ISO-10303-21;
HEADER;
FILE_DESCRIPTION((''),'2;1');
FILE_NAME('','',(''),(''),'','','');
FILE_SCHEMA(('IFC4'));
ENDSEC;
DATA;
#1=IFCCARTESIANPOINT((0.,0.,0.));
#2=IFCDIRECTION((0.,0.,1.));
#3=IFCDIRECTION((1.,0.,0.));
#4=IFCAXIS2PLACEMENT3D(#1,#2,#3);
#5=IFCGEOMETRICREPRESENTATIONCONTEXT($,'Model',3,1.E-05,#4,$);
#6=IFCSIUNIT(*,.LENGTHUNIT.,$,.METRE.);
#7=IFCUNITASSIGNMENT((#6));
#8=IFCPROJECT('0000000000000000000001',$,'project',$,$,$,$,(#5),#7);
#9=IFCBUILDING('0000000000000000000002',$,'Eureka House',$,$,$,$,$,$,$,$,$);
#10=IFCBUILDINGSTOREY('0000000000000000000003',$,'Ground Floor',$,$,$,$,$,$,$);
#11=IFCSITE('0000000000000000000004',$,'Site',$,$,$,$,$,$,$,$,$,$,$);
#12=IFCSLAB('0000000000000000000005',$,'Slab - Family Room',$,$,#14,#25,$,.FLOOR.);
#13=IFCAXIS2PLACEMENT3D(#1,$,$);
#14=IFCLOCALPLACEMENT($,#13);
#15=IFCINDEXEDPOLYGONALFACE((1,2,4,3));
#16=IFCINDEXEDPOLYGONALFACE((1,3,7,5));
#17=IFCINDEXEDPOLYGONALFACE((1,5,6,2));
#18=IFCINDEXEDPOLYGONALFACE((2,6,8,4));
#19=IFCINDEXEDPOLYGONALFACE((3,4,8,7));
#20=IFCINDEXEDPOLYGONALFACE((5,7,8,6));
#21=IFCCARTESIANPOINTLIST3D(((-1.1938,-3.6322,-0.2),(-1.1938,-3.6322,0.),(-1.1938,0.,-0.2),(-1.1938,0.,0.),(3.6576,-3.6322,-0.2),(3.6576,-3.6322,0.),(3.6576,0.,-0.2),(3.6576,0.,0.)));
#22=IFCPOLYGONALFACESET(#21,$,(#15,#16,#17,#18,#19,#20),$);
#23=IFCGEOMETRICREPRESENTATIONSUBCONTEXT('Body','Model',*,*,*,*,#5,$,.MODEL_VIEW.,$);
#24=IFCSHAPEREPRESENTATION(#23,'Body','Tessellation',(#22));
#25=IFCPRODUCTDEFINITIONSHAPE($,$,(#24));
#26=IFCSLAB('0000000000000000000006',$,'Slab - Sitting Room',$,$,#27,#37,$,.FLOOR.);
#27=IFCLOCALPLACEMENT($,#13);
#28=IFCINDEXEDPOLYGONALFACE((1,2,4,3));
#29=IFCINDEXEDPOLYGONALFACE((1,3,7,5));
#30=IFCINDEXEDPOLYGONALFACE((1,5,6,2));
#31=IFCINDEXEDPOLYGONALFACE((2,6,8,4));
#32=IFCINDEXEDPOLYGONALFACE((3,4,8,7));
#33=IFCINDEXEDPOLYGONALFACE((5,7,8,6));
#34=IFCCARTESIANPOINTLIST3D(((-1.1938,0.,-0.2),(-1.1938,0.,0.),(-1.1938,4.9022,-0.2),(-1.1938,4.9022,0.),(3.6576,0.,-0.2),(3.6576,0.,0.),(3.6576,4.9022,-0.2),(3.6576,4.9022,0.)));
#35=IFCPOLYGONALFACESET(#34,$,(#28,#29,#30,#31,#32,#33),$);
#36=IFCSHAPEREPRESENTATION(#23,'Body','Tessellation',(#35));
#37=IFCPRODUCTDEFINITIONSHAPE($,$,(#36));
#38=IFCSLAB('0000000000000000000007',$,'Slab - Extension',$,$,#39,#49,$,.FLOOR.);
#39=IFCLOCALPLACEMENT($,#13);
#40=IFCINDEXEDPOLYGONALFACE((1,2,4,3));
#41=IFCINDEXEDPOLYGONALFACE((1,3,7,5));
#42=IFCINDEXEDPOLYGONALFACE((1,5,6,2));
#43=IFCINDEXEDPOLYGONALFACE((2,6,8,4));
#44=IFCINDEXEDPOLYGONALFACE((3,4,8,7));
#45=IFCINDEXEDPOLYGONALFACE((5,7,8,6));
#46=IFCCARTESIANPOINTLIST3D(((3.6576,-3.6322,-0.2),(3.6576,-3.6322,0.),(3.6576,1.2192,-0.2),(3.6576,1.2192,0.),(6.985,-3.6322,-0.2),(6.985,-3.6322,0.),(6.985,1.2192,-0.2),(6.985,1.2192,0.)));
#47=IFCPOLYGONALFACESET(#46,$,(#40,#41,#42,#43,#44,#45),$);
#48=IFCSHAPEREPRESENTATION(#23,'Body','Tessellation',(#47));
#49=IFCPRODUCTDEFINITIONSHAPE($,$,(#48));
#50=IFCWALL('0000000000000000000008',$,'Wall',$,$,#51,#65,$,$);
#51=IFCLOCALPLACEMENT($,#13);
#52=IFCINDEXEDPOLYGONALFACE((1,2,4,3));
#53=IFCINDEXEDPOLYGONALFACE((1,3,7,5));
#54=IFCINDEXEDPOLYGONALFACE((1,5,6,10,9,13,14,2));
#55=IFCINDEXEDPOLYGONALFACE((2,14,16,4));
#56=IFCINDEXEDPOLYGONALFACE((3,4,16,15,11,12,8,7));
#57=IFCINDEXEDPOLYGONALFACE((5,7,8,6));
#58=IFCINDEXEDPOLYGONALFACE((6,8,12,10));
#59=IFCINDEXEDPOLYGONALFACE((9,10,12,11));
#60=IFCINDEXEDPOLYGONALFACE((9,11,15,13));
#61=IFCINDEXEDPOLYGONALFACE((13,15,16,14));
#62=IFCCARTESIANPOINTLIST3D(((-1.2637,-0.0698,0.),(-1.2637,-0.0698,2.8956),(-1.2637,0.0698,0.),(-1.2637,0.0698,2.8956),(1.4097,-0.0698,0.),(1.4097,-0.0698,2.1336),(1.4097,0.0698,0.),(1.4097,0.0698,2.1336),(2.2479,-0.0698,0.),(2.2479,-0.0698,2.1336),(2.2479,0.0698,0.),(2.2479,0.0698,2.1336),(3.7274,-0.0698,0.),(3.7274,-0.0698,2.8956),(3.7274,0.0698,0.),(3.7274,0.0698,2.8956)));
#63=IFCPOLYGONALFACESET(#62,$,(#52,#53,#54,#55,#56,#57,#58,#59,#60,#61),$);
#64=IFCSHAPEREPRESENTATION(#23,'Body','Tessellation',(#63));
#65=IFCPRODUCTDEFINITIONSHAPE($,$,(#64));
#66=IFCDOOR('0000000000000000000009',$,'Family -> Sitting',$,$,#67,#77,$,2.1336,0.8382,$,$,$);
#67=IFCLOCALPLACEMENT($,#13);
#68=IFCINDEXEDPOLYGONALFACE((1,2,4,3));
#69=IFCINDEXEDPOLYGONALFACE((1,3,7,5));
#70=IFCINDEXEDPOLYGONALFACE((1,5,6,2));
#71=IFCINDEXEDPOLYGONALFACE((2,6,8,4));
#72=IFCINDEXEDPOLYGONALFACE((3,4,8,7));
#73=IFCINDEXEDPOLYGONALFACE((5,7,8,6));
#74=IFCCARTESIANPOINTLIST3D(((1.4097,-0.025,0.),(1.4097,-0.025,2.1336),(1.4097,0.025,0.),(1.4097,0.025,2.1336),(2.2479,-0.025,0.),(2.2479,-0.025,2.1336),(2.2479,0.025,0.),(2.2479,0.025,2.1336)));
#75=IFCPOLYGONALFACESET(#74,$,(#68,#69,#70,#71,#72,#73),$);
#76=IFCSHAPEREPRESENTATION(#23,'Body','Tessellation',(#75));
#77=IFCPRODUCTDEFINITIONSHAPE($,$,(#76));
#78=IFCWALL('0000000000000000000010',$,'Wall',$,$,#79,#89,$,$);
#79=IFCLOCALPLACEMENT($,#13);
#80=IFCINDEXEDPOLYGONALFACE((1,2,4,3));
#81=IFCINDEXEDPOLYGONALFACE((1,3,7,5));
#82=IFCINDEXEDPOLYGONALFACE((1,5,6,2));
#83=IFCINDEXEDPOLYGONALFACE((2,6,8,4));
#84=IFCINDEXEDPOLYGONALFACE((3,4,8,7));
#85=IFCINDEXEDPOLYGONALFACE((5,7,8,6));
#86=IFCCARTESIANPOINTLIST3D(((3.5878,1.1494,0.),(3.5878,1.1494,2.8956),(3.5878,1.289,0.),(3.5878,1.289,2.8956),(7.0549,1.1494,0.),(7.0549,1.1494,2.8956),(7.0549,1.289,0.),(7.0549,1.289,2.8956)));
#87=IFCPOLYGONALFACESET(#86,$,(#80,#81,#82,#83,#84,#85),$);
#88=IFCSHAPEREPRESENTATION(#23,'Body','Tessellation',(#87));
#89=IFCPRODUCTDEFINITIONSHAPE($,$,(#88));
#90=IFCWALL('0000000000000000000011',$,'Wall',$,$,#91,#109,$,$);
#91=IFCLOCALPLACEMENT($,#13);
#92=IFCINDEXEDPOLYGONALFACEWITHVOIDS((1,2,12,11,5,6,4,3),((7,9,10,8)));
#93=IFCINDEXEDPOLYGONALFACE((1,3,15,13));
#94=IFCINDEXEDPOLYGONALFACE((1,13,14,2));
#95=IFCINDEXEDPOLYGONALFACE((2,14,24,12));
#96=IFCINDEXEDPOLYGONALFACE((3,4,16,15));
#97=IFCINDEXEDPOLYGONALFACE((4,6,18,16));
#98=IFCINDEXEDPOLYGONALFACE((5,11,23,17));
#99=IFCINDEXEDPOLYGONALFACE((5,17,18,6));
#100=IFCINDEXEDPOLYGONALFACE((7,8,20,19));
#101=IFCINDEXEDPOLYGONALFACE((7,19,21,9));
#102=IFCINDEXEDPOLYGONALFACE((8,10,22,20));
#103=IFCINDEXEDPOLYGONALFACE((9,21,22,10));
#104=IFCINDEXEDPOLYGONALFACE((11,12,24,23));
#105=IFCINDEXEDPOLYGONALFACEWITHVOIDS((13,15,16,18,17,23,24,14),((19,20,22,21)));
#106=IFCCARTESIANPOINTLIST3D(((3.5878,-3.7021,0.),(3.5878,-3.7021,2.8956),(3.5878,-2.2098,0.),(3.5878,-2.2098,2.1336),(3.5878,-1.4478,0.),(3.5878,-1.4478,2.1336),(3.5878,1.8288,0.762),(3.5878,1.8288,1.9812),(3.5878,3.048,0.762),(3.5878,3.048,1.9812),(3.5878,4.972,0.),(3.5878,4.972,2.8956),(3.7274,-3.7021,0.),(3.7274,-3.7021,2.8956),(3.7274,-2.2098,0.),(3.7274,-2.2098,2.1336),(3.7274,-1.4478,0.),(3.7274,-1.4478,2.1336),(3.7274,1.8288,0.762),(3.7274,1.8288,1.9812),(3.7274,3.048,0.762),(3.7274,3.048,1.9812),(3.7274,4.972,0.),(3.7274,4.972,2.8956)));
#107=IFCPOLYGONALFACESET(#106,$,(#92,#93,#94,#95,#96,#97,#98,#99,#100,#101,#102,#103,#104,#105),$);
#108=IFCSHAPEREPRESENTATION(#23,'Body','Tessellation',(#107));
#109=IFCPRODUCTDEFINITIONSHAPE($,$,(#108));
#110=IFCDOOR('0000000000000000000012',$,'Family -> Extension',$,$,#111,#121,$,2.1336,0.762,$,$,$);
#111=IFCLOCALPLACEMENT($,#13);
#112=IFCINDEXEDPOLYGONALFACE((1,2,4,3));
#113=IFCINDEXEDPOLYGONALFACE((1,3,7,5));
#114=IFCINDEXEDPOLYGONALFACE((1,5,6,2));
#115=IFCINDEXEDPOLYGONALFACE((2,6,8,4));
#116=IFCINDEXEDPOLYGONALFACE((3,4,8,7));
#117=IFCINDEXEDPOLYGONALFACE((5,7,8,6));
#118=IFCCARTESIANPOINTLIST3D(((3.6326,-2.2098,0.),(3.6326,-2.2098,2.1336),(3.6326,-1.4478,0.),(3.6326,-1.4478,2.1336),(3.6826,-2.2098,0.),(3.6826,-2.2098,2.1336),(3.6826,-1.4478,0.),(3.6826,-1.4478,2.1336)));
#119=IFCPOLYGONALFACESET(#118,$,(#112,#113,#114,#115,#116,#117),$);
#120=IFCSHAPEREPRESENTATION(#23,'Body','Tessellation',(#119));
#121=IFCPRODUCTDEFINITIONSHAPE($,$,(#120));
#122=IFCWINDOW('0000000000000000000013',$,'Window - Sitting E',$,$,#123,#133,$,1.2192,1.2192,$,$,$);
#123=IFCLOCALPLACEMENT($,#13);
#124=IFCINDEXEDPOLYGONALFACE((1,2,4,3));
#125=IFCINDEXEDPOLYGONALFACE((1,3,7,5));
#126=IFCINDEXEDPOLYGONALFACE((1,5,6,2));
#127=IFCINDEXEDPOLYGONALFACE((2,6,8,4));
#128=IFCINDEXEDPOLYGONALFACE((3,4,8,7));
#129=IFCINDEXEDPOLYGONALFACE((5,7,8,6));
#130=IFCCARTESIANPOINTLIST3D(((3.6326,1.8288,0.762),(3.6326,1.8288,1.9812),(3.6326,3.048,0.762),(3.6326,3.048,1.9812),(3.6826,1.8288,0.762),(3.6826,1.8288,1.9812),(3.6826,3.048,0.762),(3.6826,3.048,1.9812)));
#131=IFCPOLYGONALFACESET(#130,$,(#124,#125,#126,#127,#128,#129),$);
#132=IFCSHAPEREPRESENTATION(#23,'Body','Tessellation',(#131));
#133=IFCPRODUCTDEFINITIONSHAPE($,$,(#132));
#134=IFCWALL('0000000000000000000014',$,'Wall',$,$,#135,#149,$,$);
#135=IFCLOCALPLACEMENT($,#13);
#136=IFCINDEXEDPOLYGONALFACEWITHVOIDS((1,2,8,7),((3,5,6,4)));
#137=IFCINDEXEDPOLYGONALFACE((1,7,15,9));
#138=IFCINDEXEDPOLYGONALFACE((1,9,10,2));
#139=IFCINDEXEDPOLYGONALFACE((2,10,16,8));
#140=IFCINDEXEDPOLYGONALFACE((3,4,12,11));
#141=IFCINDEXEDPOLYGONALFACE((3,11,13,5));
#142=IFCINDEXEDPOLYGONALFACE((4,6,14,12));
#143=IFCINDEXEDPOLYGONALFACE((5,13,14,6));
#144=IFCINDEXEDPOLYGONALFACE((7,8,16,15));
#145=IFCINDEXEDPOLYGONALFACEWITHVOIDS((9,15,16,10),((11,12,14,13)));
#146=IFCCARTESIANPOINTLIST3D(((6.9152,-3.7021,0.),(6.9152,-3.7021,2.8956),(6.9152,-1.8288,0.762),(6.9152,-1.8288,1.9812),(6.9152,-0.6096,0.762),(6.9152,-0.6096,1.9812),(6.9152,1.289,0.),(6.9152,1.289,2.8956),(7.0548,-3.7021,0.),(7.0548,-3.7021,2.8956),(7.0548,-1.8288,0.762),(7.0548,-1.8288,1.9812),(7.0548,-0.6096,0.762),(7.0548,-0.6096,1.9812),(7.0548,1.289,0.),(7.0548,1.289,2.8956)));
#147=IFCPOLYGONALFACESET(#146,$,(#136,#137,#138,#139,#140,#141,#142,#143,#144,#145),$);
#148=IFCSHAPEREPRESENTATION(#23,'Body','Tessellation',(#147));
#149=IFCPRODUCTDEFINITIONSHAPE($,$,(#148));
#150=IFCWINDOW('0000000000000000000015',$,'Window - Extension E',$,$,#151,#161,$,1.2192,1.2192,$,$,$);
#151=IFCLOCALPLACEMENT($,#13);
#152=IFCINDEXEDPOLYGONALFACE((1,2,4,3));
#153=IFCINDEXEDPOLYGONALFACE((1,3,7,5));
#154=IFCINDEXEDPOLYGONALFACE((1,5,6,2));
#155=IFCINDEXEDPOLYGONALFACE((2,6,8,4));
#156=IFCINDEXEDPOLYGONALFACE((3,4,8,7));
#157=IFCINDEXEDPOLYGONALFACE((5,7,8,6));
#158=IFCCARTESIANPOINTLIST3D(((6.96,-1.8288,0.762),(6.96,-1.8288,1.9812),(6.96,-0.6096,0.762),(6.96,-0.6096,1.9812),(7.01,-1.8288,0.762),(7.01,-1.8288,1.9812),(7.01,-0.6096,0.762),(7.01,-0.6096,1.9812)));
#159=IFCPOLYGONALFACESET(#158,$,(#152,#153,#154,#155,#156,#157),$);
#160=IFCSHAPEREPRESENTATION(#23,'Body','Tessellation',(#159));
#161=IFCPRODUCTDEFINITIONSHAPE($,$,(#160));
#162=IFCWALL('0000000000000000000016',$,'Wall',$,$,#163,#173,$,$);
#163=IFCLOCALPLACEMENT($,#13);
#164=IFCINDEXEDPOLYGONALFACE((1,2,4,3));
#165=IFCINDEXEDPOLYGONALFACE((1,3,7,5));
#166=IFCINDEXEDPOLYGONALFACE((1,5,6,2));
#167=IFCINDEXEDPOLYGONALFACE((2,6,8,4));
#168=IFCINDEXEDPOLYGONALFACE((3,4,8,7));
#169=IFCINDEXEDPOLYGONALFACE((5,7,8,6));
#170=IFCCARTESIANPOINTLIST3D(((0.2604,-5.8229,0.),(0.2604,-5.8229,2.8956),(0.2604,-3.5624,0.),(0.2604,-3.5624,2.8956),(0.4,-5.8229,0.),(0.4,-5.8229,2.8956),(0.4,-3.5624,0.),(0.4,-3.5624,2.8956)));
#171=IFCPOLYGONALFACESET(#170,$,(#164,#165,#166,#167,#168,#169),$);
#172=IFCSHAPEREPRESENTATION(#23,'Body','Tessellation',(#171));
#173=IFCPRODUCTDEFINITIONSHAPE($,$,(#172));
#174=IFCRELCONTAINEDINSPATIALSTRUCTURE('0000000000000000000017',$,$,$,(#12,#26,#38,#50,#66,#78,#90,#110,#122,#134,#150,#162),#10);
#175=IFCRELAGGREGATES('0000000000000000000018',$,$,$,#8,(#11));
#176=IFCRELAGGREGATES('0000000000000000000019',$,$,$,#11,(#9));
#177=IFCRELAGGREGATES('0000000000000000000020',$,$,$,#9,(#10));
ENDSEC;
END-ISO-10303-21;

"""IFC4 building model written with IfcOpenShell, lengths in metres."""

from ifc_helpers import new_model, si_unit, frame, origin, origin_with_axes, origin_2d, place, context, subcontext, project, spatial, rectangle, extrude, element, fill, save


model = new_model("IFC4")

# Units and contexts
model_context = context("Model", 3, precision=1e-05, world=origin_with_axes())
body_context = subcontext(model_context, "Body", "Model", "MODEL_VIEW")
ifc_project = project(units=[si_unit("LENGTHUNIT", "METRE")], contexts=[model_context])

# Site, building, storey
site = spatial("IfcSite", under=ifc_project, Name="Site")
building = spatial("IfcBuilding", under=site, Name="Eureka House")
storey = spatial("IfcBuildingStorey", under=building, Name="Ground Floor")

# Slabs
slab_1_placement = place(None, frame((1.2319, -1.8161, -0.2), z_axis=(0.0, 0.0, 1.0), x_axis=(1.0, 0.0, 0.0)))
element("IfcSlab", 1, at=slab_1_placement, inside=storey, Name="Slab - Family Room", PredefinedType="FLOOR", context=body_context, shape_type="SweptSolid", body=[
    extrude(rectangle(XDim=4.8514, YDim=3.6322, at=origin_2d()), origin(), (0.0, 0.0, 1.0), 0.2),
])
slab_2_placement = place(None, frame((1.2319, 2.4511, -0.2), z_axis=(0.0, 0.0, 1.0), x_axis=(1.0, 0.0, 0.0)))
element("IfcSlab", 2, at=slab_2_placement, inside=storey, Name="Slab - Sitting Room", PredefinedType="FLOOR", context=body_context, shape_type="SweptSolid", body=[
    extrude(rectangle(XDim=4.8514, YDim=4.9022, at=origin_2d()), origin(), (0.0, 0.0, 1.0), 0.2),
])
slab_3_placement = place(None, frame((5.3213, -1.2065, -0.2), z_axis=(0.0, 0.0, 1.0), x_axis=(1.0, 0.0, 0.0)))
element("IfcSlab", 3, at=slab_3_placement, inside=storey, Name="Slab - Extension", PredefinedType="FLOOR", context=body_context, shape_type="SweptSolid", body=[
    extrude(rectangle(XDim=3.3274, YDim=4.8514, at=origin_2d()), origin(), (0.0, 0.0, 1.0), 0.2),
])

# Wall, opening, door
wall_1_placement = place(None, frame((1.2319, 0.0, 0.0), z_axis=(0.0, 0.0, 1.0), x_axis=(1.0, 0.0, 0.0)))
wall_1 = element("IfcWall", 4, at=wall_1_placement, inside=storey, Name="Wall", context=body_context, shape_type="SweptSolid", body=[
    extrude(rectangle(XDim=4.9911, YDim=0.1397, at=origin_2d()), origin(), (0.0, 0.0, 1.0), 2.8956),
])
opening_1_placement = place(wall_1_placement, frame((0.5969, 0.0, 0.0), z_axis=(0.0, 0.0, 1.0), x_axis=(1.0, 0.0, 0.0)))
opening_1 = element("IfcOpeningElement", 5, at=opening_1_placement, cuts=wall_1, context=body_context, shape_type="SweptSolid", body=[
    extrude(rectangle(XDim=0.8382, YDim=0.2397, at=origin_2d()), origin(), (0.0, 0.0, 1.0), 2.1336),
])
door_1_placement = place(opening_1_placement, origin_with_axes())
door_1 = element("IfcDoor", 6, at=door_1_placement, inside=storey, Name="Family -> Sitting", OverallHeight=2.1336, OverallWidth=0.8382, context=body_context, shape_type="SweptSolid", body=[
    extrude(rectangle(XDim=0.8382, YDim=0.05, at=origin_2d()), origin(), (0.0, 0.0, 1.0), 2.1336),
])
fill(opening_1, door_1)

# Wall
wall_2_placement = place(None, frame((5.3213, 1.2192, 0.0), z_axis=(0.0, 0.0, 1.0), x_axis=(1.0, 0.0, 0.0)))
element("IfcWall", 7, at=wall_2_placement, inside=storey, Name="Wall", context=body_context, shape_type="SweptSolid", body=[
    extrude(rectangle(XDim=3.4671, YDim=0.1397, at=origin_2d()), origin(), (0.0, 0.0, 1.0), 2.8956),
])

# Wall, openings, door, window
wall_3_placement = place(None, frame((3.6576, 0.635, 0.0), z_axis=(0.0, 0.0, 1.0), x_axis=(1.0, 0.0, 0.0)))
wall_3 = element("IfcWall", 8, at=wall_3_placement, inside=storey, Name="Wall", context=body_context, shape_type="SweptSolid", body=[
    extrude(rectangle(XDim=0.1397, YDim=8.6741, at=origin_2d()), origin(), (0.0, 0.0, 1.0), 2.8956),
])
opening_2_placement = place(wall_3_placement, frame((0.0, -2.4638, 0.0), z_axis=(0.0, 0.0, 1.0), x_axis=(1.0, 0.0, 0.0)))
opening_2 = element("IfcOpeningElement", 9, at=opening_2_placement, cuts=wall_3, context=body_context, shape_type="SweptSolid", body=[
    extrude(rectangle(XDim=0.2397, YDim=0.762, at=origin_2d()), origin(), (0.0, 0.0, 1.0), 2.1336),
])
opening_3_placement = place(wall_3_placement, frame((0.0, 1.8034, 0.762), z_axis=(0.0, 0.0, 1.0), x_axis=(1.0, 0.0, 0.0)))
opening_3 = element("IfcOpeningElement", 10, at=opening_3_placement, cuts=wall_3, context=body_context, shape_type="SweptSolid", body=[
    extrude(rectangle(XDim=0.2397, YDim=1.2192, at=origin_2d()), origin(), (0.0, 0.0, 1.0), 1.2192),
])
door_2_placement = place(opening_2_placement, origin_with_axes())
door_2 = element("IfcDoor", 11, at=door_2_placement, inside=storey, Name="Family -> Extension", OverallHeight=2.1336, OverallWidth=0.762, context=body_context, shape_type="SweptSolid", body=[
    extrude(rectangle(XDim=0.05, YDim=0.762, at=origin_2d()), origin(), (0.0, 0.0, 1.0), 2.1336),
])
fill(opening_2, door_2)
window_1_placement = place(opening_3_placement, origin_with_axes())
window_1 = element("IfcWindow", 12, at=window_1_placement, inside=storey, Name="Window - Sitting E", OverallHeight=1.2192, OverallWidth=1.2192, context=body_context, shape_type="SweptSolid", body=[
    extrude(rectangle(XDim=0.05, YDim=1.2192, at=origin_2d()), origin(), (0.0, 0.0, 1.0), 1.2192),
])
fill(opening_3, window_1)

# Wall, opening, window
wall_4_placement = place(None, frame((6.985, -1.2065, 0.0), z_axis=(0.0, 0.0, 1.0), x_axis=(1.0, 0.0, 0.0)))
wall_4 = element("IfcWall", 13, at=wall_4_placement, inside=storey, Name="Wall", context=body_context, shape_type="SweptSolid", body=[
    extrude(rectangle(XDim=0.1397, YDim=4.9911, at=origin_2d()), origin(), (0.0, 0.0, 1.0), 2.8956),
])
opening_4_placement = place(wall_4_placement, frame((0.0, -0.0127, 0.762), z_axis=(0.0, 0.0, 1.0), x_axis=(1.0, 0.0, 0.0)))
opening_4 = element("IfcOpeningElement", 14, at=opening_4_placement, cuts=wall_4, context=body_context, shape_type="SweptSolid", body=[
    extrude(rectangle(XDim=0.2397, YDim=1.2192, at=origin_2d()), origin(), (0.0, 0.0, 1.0), 1.2192),
])
window_2_placement = place(opening_4_placement, origin_with_axes())
window_2 = element("IfcWindow", 15, at=window_2_placement, inside=storey, Name="Window - Extension E", OverallHeight=1.2192, OverallWidth=1.2192, context=body_context, shape_type="SweptSolid", body=[
    extrude(rectangle(XDim=0.05, YDim=1.2192, at=origin_2d()), origin(), (0.0, 0.0, 1.0), 1.2192),
])
fill(opening_4, window_2)

# Wall
wall_5_placement = place(None, frame((0.3302, -4.6927, 0.0), z_axis=(0.0, 0.0, 1.0), x_axis=(1.0, 0.0, 0.0)))
element("IfcWall", 16, at=wall_5_placement, inside=storey, Name="Wall", context=body_context, shape_type="SweptSolid", body=[
    extrude(rectangle(XDim=0.1397, YDim=2.2606, at=origin_2d()), origin(), (0.0, 0.0, 1.0), 2.8956),
])

save(model, "model.ifc")
